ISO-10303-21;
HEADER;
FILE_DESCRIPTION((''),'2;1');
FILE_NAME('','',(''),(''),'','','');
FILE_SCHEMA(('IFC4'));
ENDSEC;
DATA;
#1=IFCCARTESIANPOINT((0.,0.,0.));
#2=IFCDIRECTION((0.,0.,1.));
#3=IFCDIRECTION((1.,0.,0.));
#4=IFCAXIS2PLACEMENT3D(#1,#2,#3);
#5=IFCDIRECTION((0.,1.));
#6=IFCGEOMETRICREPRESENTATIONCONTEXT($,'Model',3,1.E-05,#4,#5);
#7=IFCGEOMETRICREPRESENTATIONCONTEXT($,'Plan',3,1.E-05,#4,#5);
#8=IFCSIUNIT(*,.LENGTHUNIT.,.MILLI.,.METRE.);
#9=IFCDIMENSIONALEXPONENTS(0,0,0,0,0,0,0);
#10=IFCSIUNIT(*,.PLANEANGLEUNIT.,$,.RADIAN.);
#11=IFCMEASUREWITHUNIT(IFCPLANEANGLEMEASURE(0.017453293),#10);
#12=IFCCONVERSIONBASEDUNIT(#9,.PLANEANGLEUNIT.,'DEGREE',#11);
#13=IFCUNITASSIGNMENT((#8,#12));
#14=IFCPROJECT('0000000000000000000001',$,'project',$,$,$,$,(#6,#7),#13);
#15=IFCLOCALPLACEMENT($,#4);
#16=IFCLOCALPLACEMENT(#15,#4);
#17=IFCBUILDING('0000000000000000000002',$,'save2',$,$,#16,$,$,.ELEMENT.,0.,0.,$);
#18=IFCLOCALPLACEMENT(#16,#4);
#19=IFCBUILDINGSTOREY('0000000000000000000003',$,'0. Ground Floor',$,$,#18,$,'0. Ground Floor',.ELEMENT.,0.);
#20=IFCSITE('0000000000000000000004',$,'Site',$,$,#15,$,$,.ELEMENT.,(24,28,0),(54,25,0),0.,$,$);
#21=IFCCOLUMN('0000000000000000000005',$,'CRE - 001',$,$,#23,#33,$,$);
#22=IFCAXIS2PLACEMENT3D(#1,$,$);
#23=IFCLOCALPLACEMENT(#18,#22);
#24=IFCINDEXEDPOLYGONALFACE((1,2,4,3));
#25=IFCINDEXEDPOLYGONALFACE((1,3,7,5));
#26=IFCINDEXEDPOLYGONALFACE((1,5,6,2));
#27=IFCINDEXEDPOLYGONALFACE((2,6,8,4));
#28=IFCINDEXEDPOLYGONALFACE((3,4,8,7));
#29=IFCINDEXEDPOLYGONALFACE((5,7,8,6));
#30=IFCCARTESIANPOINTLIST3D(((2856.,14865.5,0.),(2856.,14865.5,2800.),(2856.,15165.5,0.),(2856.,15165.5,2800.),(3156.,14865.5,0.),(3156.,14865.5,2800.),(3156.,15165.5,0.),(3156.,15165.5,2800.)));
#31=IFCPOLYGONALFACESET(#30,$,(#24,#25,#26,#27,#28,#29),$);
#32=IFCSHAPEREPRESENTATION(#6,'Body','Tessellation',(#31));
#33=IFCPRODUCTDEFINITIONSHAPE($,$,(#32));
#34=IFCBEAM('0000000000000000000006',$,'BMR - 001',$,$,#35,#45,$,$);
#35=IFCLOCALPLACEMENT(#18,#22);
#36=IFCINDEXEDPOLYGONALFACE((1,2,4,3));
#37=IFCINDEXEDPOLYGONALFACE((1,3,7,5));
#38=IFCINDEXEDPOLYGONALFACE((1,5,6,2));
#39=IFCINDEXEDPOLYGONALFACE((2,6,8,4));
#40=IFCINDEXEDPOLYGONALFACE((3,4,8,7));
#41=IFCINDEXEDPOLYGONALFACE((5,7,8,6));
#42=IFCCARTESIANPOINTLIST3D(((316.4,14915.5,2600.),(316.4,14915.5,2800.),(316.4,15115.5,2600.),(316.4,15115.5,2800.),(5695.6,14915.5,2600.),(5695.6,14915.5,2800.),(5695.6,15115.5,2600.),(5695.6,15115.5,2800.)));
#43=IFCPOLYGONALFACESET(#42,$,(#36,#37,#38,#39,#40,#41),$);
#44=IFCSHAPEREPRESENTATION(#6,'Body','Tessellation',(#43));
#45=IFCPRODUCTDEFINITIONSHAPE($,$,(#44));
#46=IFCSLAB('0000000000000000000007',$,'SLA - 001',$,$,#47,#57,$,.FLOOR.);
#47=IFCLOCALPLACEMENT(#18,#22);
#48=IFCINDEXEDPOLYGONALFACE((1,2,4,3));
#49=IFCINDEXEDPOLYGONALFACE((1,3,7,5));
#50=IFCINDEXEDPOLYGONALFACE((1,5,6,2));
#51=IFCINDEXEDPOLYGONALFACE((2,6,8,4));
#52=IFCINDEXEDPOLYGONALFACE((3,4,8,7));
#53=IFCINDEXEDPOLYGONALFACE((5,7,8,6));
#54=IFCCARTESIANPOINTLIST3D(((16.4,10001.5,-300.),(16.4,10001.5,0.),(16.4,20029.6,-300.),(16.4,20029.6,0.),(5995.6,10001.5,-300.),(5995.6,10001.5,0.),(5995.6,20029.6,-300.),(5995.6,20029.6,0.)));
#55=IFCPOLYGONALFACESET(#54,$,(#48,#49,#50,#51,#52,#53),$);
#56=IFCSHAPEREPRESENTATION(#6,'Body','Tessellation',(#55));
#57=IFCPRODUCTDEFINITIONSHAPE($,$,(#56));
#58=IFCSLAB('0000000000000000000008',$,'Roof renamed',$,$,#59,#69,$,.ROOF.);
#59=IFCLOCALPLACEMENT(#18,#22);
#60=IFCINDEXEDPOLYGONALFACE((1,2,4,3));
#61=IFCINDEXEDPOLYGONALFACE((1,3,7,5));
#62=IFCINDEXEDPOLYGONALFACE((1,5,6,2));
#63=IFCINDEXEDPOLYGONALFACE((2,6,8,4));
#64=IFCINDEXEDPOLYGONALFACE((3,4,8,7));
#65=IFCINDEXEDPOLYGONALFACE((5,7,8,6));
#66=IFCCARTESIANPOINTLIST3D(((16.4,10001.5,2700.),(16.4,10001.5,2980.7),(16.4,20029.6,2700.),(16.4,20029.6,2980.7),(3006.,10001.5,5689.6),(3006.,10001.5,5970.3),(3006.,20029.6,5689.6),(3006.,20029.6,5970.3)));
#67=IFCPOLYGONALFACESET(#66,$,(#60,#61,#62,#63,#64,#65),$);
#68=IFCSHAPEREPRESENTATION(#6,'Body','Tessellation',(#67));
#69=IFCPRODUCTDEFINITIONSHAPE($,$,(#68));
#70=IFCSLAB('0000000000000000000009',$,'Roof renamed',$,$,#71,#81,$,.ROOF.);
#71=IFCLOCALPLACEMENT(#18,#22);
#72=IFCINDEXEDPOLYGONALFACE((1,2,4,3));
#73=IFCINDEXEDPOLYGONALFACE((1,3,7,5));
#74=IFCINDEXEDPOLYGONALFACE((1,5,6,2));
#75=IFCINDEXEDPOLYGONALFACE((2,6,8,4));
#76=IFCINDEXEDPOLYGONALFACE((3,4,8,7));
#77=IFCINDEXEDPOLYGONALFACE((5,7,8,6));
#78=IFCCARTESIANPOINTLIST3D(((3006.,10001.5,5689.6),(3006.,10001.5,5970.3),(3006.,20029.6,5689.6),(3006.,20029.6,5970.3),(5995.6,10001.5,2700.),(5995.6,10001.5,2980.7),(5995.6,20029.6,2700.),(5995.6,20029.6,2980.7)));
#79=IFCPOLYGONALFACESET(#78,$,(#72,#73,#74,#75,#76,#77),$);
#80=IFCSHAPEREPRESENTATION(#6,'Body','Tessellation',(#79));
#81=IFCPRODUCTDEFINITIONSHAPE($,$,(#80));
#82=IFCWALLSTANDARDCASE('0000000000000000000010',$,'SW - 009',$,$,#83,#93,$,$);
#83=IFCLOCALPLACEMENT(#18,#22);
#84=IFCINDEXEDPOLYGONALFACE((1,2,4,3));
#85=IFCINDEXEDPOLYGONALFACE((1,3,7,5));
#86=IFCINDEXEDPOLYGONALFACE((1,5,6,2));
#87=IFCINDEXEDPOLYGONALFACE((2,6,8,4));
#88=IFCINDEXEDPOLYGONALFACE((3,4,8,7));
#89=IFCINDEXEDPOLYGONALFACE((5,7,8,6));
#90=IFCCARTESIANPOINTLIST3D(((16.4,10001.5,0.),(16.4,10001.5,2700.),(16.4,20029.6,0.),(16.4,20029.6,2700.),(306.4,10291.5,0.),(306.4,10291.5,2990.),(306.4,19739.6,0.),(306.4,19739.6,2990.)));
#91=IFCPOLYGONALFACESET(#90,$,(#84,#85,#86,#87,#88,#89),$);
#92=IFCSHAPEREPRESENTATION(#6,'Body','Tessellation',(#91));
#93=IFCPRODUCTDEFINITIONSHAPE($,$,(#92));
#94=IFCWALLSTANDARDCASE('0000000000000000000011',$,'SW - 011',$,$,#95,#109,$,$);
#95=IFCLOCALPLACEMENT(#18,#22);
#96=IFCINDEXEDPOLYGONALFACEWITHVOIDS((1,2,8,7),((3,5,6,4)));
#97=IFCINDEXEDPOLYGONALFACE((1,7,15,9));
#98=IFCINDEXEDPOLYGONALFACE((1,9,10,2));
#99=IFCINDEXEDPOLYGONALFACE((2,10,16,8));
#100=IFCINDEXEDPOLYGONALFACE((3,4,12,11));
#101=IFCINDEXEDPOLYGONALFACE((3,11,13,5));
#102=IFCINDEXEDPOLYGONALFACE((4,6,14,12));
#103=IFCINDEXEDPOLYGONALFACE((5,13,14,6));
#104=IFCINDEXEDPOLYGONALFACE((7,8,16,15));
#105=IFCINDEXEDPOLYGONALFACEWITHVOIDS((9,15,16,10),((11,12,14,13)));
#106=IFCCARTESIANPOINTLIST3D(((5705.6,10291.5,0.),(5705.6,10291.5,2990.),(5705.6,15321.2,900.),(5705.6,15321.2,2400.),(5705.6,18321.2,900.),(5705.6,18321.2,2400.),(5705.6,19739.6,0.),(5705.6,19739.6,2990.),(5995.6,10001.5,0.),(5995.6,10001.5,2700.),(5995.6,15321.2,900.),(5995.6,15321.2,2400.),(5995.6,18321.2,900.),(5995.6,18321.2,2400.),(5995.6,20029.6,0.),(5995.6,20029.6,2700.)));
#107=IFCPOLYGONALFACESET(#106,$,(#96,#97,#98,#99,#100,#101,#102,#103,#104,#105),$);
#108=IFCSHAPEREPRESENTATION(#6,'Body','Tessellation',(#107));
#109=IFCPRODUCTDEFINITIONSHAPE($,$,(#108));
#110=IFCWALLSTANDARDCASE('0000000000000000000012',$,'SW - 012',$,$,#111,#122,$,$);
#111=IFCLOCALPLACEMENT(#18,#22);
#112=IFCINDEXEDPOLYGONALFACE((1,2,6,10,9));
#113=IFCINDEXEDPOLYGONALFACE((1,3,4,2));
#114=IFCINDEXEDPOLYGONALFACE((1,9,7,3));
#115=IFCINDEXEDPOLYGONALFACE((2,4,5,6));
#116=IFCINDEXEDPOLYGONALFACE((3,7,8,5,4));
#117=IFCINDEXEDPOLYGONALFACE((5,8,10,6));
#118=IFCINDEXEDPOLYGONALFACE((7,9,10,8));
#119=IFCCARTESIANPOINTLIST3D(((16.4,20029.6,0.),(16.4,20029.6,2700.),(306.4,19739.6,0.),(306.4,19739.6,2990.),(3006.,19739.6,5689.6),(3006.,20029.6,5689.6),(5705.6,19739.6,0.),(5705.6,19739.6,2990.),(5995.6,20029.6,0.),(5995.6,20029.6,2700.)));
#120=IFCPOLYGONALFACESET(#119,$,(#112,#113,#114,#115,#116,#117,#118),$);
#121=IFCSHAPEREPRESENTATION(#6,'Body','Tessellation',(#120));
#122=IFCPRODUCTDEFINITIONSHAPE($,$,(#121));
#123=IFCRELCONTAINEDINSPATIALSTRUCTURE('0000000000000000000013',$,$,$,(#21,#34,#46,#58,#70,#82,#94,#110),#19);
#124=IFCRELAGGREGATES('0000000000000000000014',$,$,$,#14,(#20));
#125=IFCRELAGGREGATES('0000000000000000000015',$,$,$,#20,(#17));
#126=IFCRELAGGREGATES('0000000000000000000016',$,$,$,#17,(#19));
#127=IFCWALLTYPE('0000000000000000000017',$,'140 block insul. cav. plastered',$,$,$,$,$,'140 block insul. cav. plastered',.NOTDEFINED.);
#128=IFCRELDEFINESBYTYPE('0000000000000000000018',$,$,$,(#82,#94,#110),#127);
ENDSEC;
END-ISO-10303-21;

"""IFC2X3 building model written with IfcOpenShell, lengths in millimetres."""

from ifc_helpers import new_model, entity, si_unit, converted_unit, direction, frame, frame_2d, origin_with_axes, origin_2d_with_axis, place, context, project, spatial, polyline, rectangle, outline, extrude, clip, halfspace, bounded_halfspace, type_object, element, save


model = new_model("IFC2X3")

# Units and contexts
model_context = context("Model", 3, precision=1e-05, world=origin_with_axes(), true_north=direction((0.0, 1.0)))
plan_context = context("Plan", 3, precision=1e-05, world=origin_with_axes(), true_north=direction((0.0, 1.0)))
ifc_project = project(units=[si_unit("LENGTHUNIT", "METRE", prefix="MILLI"), converted_unit("PLANEANGLEUNIT", "DEGREE", entity("IfcPlaneAngleMeasure", 0.017453293), si_unit("PLANEANGLEUNIT", "RADIAN"), dimensions=[0, 0, 0, 0, 0, 0, 0])], contexts=[model_context, plan_context])

# Site, building, storey
site_placement = place(None, origin_with_axes())
site = spatial("IfcSite", under=ifc_project, at=site_placement, Name="Site", CompositionType="ELEMENT", RefLatitude=(24, 28, 0), RefLongitude=(54, 25, 0), RefElevation=0.0)
building_placement = place(site_placement, origin_with_axes())
building = spatial("IfcBuilding", under=site, at=building_placement, Name="save2", CompositionType="ELEMENT", ElevationOfRefHeight=0.0, ElevationOfTerrain=0.0)
storey_placement = place(building_placement, origin_with_axes())
storey = spatial("IfcBuildingStorey", under=building, at=storey_placement, Name="0. Ground Floor", LongName="0. Ground Floor", CompositionType="ELEMENT", Elevation=0.0)

# Column
column_placement = place(storey_placement, frame((3006.0, 15015.5, 0.0), z_axis=(0.0, 0.0, 1.0), x_axis=(1.0, 0.0, 0.0)))
element("IfcColumn", 1, at=column_placement, inside=storey, Name="CRE - 001", context=model_context, shape_type="SweptSolid", body=[
    extrude(rectangle(XDim=300.0, YDim=300.0, at=origin_2d_with_axis()), origin_with_axes(), (0.0, 0.0, 1.0), 2800.0),
])

# Beam
beam_placement = place(storey_placement, frame((316.4, 15015.5, 2800.0), z_axis=(0.0, 0.0, 1.0), x_axis=(0.0, -1.0, 0.0)))
element("IfcBeam", 2, at=beam_placement, inside=storey, Name="BMR - 001", context=model_context, shape_type="SweptSolid", body=[
    extrude(rectangle(XDim=200.0, YDim=200.0, at=frame_2d((-100.0, 0.0), x_axis=(1.0, 0.0))), frame((0.0, 0.0, 0.0), z_axis=(0.0, 1.0, 0.0), x_axis=(0.0, 0.0, 1.0)), (0.0, 0.0, 1.0), 5379.1),
])

# Slabs
slab_1_placement = place(storey_placement, frame((16.4, 20029.6, -300.0), z_axis=(0.0, 0.0, 1.0), x_axis=(1.0, 0.0, 0.0)))
element("IfcSlab", 3, at=slab_1_placement, inside=storey, Name="SLA - 001", PredefinedType="FLOOR", context=model_context, shape_type="SweptSolid", body=[
    extrude(outline(polyline([(0.0, 0.0), (5979.1, 0.0), (5979.1, -10028.0), (0.0, -10028.0)])), origin_with_axes(), (0.0, 0.0, 1.0), 300.0),
])
slab_2_placement = place(storey_placement, frame((16.4, 20029.6, 2700.0), z_axis=(-0.707107, 0.0, 0.707107), x_axis=(0.0, -1.0, 0.0)))
element("IfcSlab", 4, at=slab_2_placement, inside=storey, Name="Roof renamed", PredefinedType="ROOF", context=model_context, shape_type="SweptSolid", body=[
    extrude(outline(polyline([(0.0, 0.0), (0.0, 4227.9), (10028.0, 4227.9), (10028.0, 0.0)])), origin_with_axes(), (0.0, 0.707107, 0.707107), 280.7),
])
slab_3_placement = place(storey_placement, frame((5995.6, 10001.5, 2700.0), z_axis=(0.707107, 0.0, 0.707107), x_axis=(0.0, 1.0, 0.0)))
element("IfcSlab", 5, at=slab_3_placement, inside=storey, Name="Roof renamed", PredefinedType="ROOF", context=model_context, shape_type="SweptSolid", body=[
    extrude(outline(polyline([(0.0, 0.0), (10028.0, 0.0), (10028.0, 4227.9), (0.0, 4227.9)])), origin_with_axes(), (0.0, 0.707107, 0.707107), 280.7),
])

# Wall
wall_type_1 = type_object("IfcWallType", Name="140 block insul. cav. plastered", ElementType="140 block insul. cav. plastered", PredefinedType="NOTDEFINED")
wall_1_placement = place(storey_placement, frame((16.4, 20029.6, 0.0), z_axis=(0.0, 0.0, 1.0), x_axis=(0.0, -1.0, 0.0)))
element("IfcWallStandardCase", 6, at=wall_1_placement, inside=storey, type_object=wall_type_1, Name="SW - 009", context=model_context, shape_type="Clipping", body=[
    clip(extrude(outline(polyline([(0.0, 0.0), (10028.0, 0.0), (9738.0, 290.0), (290.0, 290.0)])), origin_with_axes(), (0.0, 0.0, 1.0), 6000.0), halfspace(frame((0.0, -1350.0, 1350.0), z_axis=(0.0, 0.707107, -0.707107), x_axis=(0.0, 0.707107, 0.707107)), True)),
])

# Wall, opening
wall_2_placement = place(storey_placement, frame((5995.6, 10001.5, 0.0), z_axis=(0.0, 0.0, 1.0), x_axis=(0.0, 1.0, 0.0)))
wall_2 = element("IfcWallStandardCase", 7, at=wall_2_placement, inside=storey, type_object=wall_type_1, Name="SW - 011", context=model_context, shape_type="Clipping", body=[
    clip(extrude(outline(polyline([(0.0, 0.0), (10028.0, 0.0), (9738.0, 290.0), (290.0, 290.0)])), origin_with_axes(), (0.0, 0.0, 1.0), 6000.0), halfspace(frame((0.0, -1350.0, 1350.0), z_axis=(0.0, 0.707107, -0.707107), x_axis=(0.0, 0.707107, 0.707107)), True)),
])
opening_1_placement = place(wall_2_placement, frame((6819.7, 0.0, 900.0), z_axis=(0.0, 0.0, 1.0), x_axis=(1.0, 0.0, 0.0)))
element("IfcOpeningElement", 8, at=opening_1_placement, cuts=wall_2, ObjectType="Opening", context=model_context, shape_type="SweptSolid", body=[
    extrude(rectangle(XDim=3000.0, YDim=1500.0, at=frame_2d((0.0, 750.0), x_axis=(1.0, 0.0))), frame((0.0, 0.0, 0.0), z_axis=(0.0, 1.0, 0.0), x_axis=(-1.0, 0.0, 0.0)), (0.0, 0.0, 1.0), 290.0),
])

# Wall
wall_3_placement = place(storey_placement, frame((5995.6, 20029.6, 0.0), z_axis=(0.0, 0.0, 1.0), x_axis=(-1.0, 0.0, 0.0)))
element("IfcWallStandardCase", 9, at=wall_3_placement, inside=storey, type_object=wall_type_1, Name="SW - 012", context=model_context, shape_type="Clipping", body=[
    clip(clip(extrude(outline(polyline([(0.0, 0.0), (5979.1, 0.0), (5689.1, 290.0), (290.0, 290.0)])), origin_with_axes(), (0.0, 0.0, 1.0), 6000.0), bounded_halfspace(frame((4339.6, 0.0, 4339.6), z_axis=(-0.707107, 0.0, -0.707107), x_axis=(0.0, 1.0, 0.0)), True, origin_with_axes(), polyline([(2989.6, -145.0), (2989.6, 435.0), (5989.1, 435.0), (5989.1, -145.0), (2989.6, -145.0)]))), bounded_halfspace(frame((-1350.0, 0.0, 1350.0), z_axis=(0.707107, 0.0, -0.707107), x_axis=(0.0, 1.0, 0.0)), True, origin_with_axes(), polyline([(2989.6, -145.0), (2989.6, 435.0), (-10.0, 435.0), (-10.0, -145.0), (2989.6, -145.0)]))),
])

save(model, "model.ifc")
